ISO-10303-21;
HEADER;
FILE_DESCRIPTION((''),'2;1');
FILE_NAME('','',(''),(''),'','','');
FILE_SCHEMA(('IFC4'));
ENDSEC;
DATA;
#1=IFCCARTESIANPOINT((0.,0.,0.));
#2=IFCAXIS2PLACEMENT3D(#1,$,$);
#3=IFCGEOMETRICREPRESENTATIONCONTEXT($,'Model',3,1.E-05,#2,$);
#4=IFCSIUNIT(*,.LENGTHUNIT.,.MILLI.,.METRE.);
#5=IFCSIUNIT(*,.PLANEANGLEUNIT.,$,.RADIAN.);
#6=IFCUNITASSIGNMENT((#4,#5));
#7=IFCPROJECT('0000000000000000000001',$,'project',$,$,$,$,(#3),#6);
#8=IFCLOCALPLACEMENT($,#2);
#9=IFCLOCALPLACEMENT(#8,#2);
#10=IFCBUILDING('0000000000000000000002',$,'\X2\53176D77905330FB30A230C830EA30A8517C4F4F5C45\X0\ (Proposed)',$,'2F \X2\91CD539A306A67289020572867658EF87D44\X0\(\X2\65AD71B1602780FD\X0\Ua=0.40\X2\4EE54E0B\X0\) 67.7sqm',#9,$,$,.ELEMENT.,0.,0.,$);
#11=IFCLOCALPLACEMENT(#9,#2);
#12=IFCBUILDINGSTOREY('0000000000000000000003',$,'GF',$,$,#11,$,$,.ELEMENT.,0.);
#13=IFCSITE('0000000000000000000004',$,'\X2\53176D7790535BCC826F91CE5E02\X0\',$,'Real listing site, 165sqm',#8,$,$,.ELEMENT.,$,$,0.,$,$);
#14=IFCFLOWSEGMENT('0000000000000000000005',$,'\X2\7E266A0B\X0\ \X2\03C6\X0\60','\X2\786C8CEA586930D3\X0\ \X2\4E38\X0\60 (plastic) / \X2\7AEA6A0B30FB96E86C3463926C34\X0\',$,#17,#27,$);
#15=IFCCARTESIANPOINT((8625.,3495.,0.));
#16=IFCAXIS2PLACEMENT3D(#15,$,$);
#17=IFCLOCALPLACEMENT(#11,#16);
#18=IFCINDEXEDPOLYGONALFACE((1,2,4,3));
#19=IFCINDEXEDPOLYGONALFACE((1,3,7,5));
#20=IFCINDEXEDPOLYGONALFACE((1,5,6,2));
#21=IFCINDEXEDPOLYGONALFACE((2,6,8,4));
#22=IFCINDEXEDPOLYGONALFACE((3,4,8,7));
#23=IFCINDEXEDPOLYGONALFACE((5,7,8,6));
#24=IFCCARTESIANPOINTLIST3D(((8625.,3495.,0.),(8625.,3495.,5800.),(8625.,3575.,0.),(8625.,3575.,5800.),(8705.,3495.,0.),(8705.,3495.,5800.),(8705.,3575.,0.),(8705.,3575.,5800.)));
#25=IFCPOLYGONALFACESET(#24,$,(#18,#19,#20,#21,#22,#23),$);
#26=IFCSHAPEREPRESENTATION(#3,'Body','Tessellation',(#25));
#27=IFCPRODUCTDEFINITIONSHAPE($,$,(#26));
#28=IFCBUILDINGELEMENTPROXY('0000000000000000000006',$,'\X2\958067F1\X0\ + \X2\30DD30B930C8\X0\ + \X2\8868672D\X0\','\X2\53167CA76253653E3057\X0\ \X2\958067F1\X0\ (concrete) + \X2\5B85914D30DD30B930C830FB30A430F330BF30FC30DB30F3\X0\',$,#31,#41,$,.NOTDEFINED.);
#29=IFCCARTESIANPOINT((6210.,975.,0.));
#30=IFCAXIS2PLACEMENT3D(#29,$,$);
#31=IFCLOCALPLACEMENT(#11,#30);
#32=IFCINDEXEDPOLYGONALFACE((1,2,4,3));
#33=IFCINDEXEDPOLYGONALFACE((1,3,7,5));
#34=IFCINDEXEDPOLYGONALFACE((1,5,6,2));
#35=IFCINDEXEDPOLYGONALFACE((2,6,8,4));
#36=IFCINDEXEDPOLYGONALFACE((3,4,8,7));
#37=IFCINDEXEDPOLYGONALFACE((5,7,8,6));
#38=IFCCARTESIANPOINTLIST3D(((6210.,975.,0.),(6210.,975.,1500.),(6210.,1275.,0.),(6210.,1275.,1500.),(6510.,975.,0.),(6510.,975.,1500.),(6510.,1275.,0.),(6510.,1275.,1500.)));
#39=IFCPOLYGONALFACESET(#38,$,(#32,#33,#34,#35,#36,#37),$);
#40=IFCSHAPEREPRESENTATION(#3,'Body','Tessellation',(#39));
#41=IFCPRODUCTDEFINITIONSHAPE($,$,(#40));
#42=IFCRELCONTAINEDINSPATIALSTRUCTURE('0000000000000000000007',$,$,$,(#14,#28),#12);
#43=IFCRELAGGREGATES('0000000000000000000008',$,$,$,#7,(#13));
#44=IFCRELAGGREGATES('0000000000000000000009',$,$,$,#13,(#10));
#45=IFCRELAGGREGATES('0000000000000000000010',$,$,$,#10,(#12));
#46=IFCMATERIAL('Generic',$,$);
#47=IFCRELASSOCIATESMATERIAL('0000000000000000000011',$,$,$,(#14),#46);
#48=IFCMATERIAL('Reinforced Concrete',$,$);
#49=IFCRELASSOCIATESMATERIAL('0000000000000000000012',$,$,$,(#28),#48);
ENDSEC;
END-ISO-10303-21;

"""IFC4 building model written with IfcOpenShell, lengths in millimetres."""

from ifc_helpers import new_model, si_unit, frame, frame_2d, origin, place, context, project, spatial, rectangle, extrude, material, element, save


model = new_model("IFC4")

# Units and contexts
model_context = context("Model", 3, precision=1e-05, world=origin())
ifc_project = project(units=[si_unit("LENGTHUNIT", "METRE", prefix="MILLI"), si_unit("PLANEANGLEUNIT", "RADIAN")], contexts=[model_context])

# Site, building, storey
site_placement = place(None, origin())
site = spatial("IfcSite", under=ifc_project, at=site_placement, Name="北海道富良野市", ObjectType="Real listing site, 165sqm", CompositionType="ELEMENT", RefElevation=0.0)
building_placement = place(site_placement, origin())
building = spatial("IfcBuilding", under=site, at=building_placement, Name="北海道・アトリエ兼住居 (Proposed)", ObjectType="2F 重厚な木造在来軸組(断熱性能Ua=0.40以下) 67.7sqm", CompositionType="ELEMENT", ElevationOfRefHeight=0.0, ElevationOfTerrain=0.0)
storey_placement = place(building_placement, origin())
storey = spatial("IfcBuildingStorey", under=building, at=storey_placement, Name="GF", CompositionType="ELEMENT", Elevation=0.0)

# Shared definitions
ifc_material_1 = material(Name="Reinforced Concrete")

# Flow segment
ifc_material_2 = material(Name="Generic")
flow_segment_1_placement = place(storey_placement, frame((8625.0, 3495.0, 0.0)))
element("IfcFlowSegment", 1, at=flow_segment_1_placement, inside=storey, material=ifc_material_2, Name="縦樋 φ60", Description="硬質塩ビ 丸60 (plastic) / 竪樋・雨水排水", context=model_context, shape_type="SweptSolid", body=[
    extrude(rectangle(XDim=80.0, YDim=80.0, at=frame_2d((40.0, 40.0))), frame((8625.0, 3495.0, 0.0)), (0.0, 0.0, 1.0), 5800.0),
])

# Building element proxy
proxy_placement = place(storey_placement, frame((6210.0, 975.0, 0.0)))
element("IfcBuildingElementProxy", 2, at=proxy_placement, inside=storey, material=ifc_material_1, Name="門柱 + ポスト + 表札", Description="化粧打放し 門柱 (concrete) + 宅配ポスト・インターホン", PredefinedType="NOTDEFINED", context=model_context, shape_type="SweptSolid", body=[
    extrude(rectangle(XDim=300.0, YDim=300.0, at=frame_2d((150.0, 150.0))), frame((6210.0, 975.0, 0.0)), (0.0, 0.0, 1.0), 1500.0),
])

save(model, "model.ifc")
